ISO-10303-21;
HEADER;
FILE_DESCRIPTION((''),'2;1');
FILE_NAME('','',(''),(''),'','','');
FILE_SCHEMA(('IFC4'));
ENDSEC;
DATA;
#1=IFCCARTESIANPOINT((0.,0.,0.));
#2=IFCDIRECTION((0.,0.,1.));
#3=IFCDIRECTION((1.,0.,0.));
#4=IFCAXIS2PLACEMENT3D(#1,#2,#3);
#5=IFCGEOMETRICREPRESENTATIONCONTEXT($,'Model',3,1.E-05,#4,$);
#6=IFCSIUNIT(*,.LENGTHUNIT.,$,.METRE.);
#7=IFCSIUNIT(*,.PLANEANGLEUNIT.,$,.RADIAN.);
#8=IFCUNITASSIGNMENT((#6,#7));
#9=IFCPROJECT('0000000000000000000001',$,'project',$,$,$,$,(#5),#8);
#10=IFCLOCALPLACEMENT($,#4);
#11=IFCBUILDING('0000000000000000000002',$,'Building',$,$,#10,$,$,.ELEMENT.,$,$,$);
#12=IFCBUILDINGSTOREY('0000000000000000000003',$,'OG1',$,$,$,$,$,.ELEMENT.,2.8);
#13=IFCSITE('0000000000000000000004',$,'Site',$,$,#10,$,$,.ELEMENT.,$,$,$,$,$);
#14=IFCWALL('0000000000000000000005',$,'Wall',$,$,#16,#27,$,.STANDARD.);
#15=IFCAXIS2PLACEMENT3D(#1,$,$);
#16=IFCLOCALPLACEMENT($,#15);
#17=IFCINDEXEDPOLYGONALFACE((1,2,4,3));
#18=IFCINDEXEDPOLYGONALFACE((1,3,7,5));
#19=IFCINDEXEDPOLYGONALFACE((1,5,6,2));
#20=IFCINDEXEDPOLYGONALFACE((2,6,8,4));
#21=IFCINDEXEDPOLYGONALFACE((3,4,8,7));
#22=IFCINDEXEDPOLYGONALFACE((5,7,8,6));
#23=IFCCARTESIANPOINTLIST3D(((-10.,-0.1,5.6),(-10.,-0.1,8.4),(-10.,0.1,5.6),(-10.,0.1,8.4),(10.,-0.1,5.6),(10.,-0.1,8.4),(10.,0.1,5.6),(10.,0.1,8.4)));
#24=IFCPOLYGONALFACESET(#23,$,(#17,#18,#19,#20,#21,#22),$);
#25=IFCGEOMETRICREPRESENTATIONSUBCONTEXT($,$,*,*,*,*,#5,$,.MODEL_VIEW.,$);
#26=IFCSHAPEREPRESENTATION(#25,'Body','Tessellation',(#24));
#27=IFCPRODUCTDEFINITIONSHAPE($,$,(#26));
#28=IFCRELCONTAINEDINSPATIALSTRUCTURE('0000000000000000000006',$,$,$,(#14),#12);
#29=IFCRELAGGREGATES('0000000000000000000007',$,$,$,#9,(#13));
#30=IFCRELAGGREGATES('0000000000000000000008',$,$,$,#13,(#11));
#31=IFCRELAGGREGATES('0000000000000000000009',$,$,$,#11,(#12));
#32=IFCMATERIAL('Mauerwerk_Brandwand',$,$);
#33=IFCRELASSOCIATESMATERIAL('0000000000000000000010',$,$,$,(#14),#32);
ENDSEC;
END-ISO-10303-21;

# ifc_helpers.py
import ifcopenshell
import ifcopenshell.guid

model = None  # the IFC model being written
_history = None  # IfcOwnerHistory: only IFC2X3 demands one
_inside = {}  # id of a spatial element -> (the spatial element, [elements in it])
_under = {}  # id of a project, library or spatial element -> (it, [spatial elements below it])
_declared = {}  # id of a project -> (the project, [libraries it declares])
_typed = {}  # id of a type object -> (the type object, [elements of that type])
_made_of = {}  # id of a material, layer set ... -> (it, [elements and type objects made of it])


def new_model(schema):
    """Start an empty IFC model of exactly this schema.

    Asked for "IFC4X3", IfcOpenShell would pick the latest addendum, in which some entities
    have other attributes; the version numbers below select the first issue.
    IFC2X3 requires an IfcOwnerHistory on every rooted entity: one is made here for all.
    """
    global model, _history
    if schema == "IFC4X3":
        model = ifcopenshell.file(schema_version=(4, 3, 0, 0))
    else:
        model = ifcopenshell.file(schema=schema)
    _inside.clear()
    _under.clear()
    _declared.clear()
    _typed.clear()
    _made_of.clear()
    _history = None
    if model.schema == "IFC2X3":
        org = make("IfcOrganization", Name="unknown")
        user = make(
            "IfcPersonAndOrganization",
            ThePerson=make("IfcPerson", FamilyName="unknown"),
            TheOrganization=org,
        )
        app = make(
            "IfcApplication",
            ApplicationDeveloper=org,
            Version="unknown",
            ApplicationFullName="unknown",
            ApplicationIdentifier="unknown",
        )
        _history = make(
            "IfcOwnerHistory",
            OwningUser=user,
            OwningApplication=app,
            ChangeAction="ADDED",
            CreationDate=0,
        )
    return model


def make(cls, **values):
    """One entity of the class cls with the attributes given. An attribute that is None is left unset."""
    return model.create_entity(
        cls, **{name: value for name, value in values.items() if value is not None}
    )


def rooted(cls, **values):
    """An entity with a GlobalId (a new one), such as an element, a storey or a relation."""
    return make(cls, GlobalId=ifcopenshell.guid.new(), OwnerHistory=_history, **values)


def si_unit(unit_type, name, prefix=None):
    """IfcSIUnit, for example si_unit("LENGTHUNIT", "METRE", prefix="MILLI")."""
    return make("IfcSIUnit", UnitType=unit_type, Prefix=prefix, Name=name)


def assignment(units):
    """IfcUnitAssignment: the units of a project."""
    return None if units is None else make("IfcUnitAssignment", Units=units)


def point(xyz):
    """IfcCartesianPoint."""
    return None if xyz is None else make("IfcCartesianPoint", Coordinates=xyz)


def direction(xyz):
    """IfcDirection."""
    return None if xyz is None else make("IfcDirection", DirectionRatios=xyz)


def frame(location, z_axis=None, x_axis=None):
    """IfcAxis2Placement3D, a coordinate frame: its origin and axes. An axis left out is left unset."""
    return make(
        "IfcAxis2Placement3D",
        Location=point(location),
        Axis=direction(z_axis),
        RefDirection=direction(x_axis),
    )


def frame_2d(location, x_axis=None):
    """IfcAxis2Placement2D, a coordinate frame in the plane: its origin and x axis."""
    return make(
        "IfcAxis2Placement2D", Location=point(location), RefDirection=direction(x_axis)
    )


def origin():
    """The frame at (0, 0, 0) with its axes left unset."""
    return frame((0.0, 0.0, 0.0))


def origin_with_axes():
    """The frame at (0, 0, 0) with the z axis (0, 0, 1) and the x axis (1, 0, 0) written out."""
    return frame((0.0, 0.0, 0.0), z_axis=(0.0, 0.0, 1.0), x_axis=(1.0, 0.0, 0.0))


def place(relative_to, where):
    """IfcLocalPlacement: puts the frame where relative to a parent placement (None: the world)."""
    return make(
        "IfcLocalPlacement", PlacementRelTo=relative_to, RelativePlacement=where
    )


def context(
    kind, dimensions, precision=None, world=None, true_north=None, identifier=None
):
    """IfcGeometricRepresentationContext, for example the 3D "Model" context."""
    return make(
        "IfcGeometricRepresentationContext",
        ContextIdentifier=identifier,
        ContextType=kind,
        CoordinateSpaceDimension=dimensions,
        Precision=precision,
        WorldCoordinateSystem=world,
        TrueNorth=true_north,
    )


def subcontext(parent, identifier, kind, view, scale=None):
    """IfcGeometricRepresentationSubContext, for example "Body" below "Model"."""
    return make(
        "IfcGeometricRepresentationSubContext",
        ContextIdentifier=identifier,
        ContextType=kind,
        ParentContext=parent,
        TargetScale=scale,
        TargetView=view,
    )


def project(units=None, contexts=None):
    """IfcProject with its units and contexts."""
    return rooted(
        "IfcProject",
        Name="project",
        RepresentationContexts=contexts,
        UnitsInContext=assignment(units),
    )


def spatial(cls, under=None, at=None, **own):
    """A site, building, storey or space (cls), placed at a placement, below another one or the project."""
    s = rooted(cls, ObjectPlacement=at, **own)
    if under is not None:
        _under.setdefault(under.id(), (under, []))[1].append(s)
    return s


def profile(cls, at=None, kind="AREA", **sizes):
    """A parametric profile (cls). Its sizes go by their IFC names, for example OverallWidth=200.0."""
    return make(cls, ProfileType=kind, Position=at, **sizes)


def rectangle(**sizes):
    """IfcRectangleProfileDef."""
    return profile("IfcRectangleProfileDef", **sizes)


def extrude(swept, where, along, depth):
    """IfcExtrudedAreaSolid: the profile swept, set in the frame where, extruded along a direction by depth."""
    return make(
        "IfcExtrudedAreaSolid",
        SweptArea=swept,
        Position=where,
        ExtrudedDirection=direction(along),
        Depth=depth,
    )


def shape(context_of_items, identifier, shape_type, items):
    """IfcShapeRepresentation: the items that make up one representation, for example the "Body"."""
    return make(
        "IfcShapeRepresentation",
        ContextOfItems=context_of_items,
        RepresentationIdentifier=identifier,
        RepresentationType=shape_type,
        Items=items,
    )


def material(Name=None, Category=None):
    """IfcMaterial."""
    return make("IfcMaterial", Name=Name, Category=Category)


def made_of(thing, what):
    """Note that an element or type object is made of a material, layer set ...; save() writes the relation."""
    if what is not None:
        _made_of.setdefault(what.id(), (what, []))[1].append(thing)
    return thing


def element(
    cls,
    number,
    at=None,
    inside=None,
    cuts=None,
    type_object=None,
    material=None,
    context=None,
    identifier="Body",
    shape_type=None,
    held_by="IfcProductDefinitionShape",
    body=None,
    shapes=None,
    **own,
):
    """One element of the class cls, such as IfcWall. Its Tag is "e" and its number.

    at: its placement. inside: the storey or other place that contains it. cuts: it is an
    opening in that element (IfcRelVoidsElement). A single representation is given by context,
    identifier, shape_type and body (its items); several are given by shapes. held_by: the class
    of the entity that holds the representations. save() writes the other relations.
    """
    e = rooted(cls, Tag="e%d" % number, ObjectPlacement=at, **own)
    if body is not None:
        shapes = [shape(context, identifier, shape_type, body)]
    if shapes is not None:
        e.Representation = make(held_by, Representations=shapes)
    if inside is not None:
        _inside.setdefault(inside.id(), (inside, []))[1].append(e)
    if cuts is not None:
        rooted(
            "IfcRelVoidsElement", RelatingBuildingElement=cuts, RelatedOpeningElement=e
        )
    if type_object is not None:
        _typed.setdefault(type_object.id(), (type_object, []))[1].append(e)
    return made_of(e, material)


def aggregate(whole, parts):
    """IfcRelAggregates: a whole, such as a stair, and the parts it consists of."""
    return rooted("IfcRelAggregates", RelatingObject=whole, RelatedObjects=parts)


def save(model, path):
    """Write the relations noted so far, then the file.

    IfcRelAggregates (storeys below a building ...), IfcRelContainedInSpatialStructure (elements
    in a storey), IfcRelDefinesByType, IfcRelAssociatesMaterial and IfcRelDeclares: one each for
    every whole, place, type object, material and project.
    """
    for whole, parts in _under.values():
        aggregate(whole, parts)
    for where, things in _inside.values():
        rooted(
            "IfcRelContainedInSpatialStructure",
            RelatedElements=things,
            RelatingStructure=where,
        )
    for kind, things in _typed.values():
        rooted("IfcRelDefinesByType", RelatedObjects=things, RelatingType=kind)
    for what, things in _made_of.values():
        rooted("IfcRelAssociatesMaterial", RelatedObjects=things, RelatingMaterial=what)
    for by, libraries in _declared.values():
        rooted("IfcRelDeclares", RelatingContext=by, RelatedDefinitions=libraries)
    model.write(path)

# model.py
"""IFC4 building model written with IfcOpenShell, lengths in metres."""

from ifc_helpers import new_model, si_unit, frame, frame_2d, origin, origin_with_axes, place, context, subcontext, project, spatial, rectangle, extrude, material, element, save


model = new_model("IFC4")

# Units and contexts
model_context = context("Model", 3, precision=1e-05, world=origin_with_axes())
sub_context = subcontext(model_context, None, None, "MODEL_VIEW")
ifc_project = project(units=[si_unit("LENGTHUNIT", "METRE"), si_unit("PLANEANGLEUNIT", "RADIAN")], contexts=[model_context])

# Site, building, storey
placement_1 = place(None, origin_with_axes())
site = spatial("IfcSite", under=ifc_project, at=placement_1, Name="Site", CompositionType="ELEMENT")
building = spatial("IfcBuilding", under=site, at=placement_1, Name="Building", CompositionType="ELEMENT")
storey = spatial("IfcBuildingStorey", under=building, Name="OG1", CompositionType="ELEMENT", Elevation=2.8)

# Wall
ifc_material = material(Name="Mauerwerk_Brandwand")
placement_2 = place(None, origin_with_axes())
placement_3 = place(placement_2, frame((0.0, 0.0, 2.8)))
wall_placement = place(placement_3, frame((-10.0, 0.0, 2.8), x_axis=(1.0, 0.0, 0.0)))
element("IfcWall", 1, at=wall_placement, inside=storey, material=ifc_material, Name="Wall", PredefinedType="STANDARD", context=sub_context, shape_type="SweptSolid", body=[
    extrude(rectangle(XDim=20.0, YDim=0.2, at=frame_2d((10.0, 0.0))), origin(), (0.0, 0.0, 1.0), 2.8),
])

save(model, "model.ifc")
